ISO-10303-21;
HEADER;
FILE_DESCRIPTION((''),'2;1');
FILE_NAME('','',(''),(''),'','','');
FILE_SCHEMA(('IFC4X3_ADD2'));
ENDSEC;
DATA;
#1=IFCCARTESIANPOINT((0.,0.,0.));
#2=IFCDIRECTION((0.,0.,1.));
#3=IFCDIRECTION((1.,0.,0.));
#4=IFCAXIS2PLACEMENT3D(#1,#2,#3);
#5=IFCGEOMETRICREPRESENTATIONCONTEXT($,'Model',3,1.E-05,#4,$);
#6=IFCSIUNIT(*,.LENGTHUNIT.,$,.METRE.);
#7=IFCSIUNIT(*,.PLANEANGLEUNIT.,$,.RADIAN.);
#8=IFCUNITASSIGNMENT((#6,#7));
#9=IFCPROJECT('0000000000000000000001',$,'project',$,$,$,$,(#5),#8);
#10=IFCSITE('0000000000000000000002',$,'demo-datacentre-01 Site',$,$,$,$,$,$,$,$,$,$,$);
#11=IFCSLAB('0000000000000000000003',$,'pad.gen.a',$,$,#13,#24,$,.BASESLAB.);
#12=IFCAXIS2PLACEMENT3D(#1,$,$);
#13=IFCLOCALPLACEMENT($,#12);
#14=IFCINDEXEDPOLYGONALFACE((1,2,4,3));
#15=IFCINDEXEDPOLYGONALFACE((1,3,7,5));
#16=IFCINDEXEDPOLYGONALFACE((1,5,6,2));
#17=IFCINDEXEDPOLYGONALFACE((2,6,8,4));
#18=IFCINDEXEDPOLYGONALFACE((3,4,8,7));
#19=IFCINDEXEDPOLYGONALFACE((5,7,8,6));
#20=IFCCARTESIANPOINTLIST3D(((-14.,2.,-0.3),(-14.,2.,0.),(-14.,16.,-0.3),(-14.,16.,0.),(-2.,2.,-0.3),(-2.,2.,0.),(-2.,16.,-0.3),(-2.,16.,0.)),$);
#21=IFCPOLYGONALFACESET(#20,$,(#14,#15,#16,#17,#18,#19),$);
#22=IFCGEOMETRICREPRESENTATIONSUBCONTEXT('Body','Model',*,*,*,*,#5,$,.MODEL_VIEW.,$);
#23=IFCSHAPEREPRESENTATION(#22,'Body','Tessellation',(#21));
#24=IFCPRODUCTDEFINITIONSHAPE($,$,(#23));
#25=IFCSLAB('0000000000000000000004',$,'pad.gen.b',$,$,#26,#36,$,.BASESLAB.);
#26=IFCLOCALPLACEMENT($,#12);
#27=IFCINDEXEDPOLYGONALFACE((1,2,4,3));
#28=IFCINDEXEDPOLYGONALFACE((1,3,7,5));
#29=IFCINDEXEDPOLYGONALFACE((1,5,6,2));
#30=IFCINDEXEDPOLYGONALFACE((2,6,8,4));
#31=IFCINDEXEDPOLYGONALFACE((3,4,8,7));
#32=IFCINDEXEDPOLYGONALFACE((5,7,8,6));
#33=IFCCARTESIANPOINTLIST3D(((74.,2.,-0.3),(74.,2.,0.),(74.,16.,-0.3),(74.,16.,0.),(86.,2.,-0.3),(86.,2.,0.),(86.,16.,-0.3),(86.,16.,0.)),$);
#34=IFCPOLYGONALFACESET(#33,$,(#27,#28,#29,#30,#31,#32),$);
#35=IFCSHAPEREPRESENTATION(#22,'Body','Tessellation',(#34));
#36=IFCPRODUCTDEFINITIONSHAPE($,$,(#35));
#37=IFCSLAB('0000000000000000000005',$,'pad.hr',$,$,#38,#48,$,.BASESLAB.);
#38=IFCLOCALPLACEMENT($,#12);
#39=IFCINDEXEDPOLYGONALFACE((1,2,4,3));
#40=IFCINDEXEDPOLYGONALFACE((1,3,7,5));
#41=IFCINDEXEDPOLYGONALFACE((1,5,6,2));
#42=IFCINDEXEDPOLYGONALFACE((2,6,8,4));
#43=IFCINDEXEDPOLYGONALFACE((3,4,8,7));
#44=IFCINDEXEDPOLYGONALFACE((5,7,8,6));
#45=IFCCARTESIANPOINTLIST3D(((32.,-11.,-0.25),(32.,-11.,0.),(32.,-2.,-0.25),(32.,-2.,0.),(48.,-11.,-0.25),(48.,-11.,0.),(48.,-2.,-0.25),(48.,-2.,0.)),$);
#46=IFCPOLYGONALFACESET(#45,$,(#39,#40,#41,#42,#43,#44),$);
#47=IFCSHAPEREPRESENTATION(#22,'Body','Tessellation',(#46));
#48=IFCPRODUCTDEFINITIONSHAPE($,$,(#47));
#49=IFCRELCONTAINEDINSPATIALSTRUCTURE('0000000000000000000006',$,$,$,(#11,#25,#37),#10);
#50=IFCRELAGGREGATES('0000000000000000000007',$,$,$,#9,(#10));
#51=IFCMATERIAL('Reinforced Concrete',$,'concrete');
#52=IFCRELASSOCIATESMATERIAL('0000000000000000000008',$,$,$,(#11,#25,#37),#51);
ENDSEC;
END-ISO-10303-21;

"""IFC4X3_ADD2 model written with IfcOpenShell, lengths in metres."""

from ifc_helpers import new_model, si_unit, frame, origin_with_axes, place, context, subcontext, project, spatial, rectangle, extrude, material, element, save


model = new_model("IFC4X3_ADD2")

# Units and contexts
model_context = context("Model", 3, precision=1e-05, world=origin_with_axes())
body_context = subcontext(model_context, "Body", "Model", "MODEL_VIEW")
ifc_project = project(units=[si_unit("LENGTHUNIT", "METRE"), si_unit("PLANEANGLEUNIT", "RADIAN")], contexts=[model_context])

# Site
site = spatial("IfcSite", under=ifc_project, Name="demo-datacentre-01 Site")

# Slabs
ifc_material = material(Name="Reinforced Concrete", Category="concrete")
for number, where, z_axis, x_axis, name in (
    (1, (-8.0, 9.0, -0.3), (0.0, 0.0, 1.0), (1.0, 0.0, 0.0), "pad.gen.a"),
    (2, (80.0, 9.0, -0.3), (0.0, 0.0, 1.0), (1.0, 0.0, 0.0), "pad.gen.b"),
):
    element("IfcSlab", number, at=place(None, frame(where, z_axis=z_axis, x_axis=x_axis)), inside=site, material=ifc_material, Name=name, PredefinedType="BASESLAB", context=body_context, shape_type="SweptSolid", body=[
        extrude(rectangle(XDim=12.0, YDim=14.0), origin_with_axes(), (0.0, 0.0, 1.0), 0.3),
    ])
slab_placement = place(None, frame((40.0, -6.5, -0.25), z_axis=(0.0, 0.0, 1.0), x_axis=(1.0, 0.0, 0.0)))
element("IfcSlab", 3, at=slab_placement, inside=site, material=ifc_material, Name="pad.hr", PredefinedType="BASESLAB", context=body_context, shape_type="SweptSolid", body=[
    extrude(rectangle(XDim=16.0, YDim=9.0), origin_with_axes(), (0.0, 0.0, 1.0), 0.25),
])

save(model, "model.ifc")
